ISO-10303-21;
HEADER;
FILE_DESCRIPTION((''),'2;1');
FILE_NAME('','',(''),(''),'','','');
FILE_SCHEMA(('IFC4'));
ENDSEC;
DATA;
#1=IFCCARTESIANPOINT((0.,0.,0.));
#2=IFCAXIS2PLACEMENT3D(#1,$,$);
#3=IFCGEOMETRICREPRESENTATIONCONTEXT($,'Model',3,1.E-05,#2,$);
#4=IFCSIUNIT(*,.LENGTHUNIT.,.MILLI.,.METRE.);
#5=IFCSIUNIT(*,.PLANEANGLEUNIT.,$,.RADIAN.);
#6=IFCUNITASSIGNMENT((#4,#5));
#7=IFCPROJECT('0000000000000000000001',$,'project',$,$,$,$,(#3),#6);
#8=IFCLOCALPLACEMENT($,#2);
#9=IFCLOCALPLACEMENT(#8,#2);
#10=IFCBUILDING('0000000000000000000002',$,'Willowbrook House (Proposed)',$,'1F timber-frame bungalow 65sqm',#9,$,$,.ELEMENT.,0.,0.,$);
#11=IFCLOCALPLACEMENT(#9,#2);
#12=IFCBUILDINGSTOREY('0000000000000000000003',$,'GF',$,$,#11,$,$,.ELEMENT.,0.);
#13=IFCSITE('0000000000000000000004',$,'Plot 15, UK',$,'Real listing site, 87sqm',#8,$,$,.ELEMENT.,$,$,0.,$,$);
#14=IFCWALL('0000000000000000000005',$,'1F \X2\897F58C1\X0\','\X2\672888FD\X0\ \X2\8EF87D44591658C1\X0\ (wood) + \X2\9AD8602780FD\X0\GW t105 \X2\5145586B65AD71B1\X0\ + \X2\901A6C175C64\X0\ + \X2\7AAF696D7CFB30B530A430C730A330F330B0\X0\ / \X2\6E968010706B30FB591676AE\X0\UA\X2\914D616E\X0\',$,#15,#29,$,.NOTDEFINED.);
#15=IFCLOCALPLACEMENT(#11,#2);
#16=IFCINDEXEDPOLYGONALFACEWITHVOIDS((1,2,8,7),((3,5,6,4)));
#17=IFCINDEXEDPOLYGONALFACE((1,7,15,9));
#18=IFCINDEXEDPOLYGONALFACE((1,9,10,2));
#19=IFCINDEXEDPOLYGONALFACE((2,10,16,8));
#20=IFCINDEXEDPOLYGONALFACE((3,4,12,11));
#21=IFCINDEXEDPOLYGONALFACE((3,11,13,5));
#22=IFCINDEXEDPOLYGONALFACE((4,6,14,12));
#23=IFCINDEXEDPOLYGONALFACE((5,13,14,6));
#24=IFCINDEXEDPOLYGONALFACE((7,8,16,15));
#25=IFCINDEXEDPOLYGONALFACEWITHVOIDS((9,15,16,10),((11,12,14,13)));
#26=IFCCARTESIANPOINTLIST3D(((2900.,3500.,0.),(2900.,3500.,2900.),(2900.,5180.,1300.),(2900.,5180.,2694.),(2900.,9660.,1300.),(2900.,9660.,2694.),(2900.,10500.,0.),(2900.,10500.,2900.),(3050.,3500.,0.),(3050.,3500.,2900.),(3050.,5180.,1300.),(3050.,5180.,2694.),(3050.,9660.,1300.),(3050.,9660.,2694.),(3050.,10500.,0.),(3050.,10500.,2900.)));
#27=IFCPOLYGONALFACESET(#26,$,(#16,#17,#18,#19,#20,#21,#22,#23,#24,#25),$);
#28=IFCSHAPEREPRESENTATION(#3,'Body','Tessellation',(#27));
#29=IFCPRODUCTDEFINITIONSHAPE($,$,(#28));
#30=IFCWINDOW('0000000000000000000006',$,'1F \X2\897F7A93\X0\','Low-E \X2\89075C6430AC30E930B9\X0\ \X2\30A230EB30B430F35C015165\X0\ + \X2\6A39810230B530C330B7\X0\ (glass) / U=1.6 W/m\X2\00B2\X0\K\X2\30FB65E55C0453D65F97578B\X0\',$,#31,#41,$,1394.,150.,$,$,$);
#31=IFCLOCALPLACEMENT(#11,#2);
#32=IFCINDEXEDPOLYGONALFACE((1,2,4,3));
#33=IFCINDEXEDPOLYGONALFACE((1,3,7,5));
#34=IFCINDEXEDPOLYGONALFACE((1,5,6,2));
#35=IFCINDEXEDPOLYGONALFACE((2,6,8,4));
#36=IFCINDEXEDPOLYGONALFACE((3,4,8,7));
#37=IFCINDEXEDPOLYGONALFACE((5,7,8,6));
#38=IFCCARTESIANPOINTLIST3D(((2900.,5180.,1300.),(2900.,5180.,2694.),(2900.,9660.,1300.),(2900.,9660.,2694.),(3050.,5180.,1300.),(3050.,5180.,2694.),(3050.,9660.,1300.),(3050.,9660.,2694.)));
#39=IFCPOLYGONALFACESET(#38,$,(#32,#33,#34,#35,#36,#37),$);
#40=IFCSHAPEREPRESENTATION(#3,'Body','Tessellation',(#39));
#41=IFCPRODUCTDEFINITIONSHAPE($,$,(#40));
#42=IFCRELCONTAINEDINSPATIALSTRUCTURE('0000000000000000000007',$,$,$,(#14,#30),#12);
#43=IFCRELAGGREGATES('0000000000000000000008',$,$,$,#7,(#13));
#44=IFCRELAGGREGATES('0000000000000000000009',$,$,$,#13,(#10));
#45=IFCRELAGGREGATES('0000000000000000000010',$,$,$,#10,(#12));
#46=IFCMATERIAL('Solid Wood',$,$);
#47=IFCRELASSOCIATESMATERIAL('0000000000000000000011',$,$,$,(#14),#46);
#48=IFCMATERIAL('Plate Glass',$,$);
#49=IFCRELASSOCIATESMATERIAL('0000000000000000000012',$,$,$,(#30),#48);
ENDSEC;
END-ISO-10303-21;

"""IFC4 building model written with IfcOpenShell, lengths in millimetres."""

from ifc_helpers import new_model, si_unit, frame, frame_2d, origin, place, context, project, spatial, rectangle, extrude, material, element, fill, save


model = new_model("IFC4")

# Units and contexts
model_context = context("Model", 3, precision=1e-05, world=origin())
ifc_project = project(units=[si_unit("LENGTHUNIT", "METRE", prefix="MILLI"), si_unit("PLANEANGLEUNIT", "RADIAN")], contexts=[model_context])

# Site, building, storey
site_placement = place(None, origin())
site = spatial("IfcSite", under=ifc_project, at=site_placement, Name="Plot 15, UK", ObjectType="Real listing site, 87sqm", CompositionType="ELEMENT", RefElevation=0.0)
building_placement = place(site_placement, origin())
building = spatial("IfcBuilding", under=site, at=building_placement, Name="Willowbrook House (Proposed)", ObjectType="1F timber-frame bungalow 65sqm", CompositionType="ELEMENT", ElevationOfRefHeight=0.0, ElevationOfTerrain=0.0)
storey_placement = place(building_placement, origin())
storey = spatial("IfcBuildingStorey", under=building, at=storey_placement, Name="GF", CompositionType="ELEMENT", Elevation=0.0)

# Shared definitions
ifc_material_1 = material(Name="Solid Wood")

# Shared definitions
ifc_material_2 = material(Name="Plate Glass")

# Wall, opening, window
wall_1_placement = place(storey_placement, frame((1450.0, 1750.0, 0.0)))
wall_1 = element("IfcWall", 1, at=wall_1_placement, inside=storey, material=ifc_material_1, Name="1F 西壁", Description="木製 軸組外壁 (wood) + 高性能GW t105 充填断熱 + 通気層 + 窯業系サイディング / 準耐火・外皮UA配慮", PredefinedType="NOTDEFINED", context=model_context, shape_type="SweptSolid", body=[
    extrude(rectangle(XDim=150.0, YDim=7000.0, at=frame_2d((75.0, 3500.0))), frame((1450.0, 1750.0, 0.0)), (0.0, 0.0, 1.0), 2900.0),
])
opening_1_placement = place(storey_placement, frame((1450.0, 2590.0, 650.0)))
opening_1 = element("IfcOpeningElement", 2, at=opening_1_placement, cuts=wall_1, PredefinedType="NOTDEFINED", context=model_context, shape_type="SweptSolid", body=[
    extrude(rectangle(XDim=150.0, YDim=4480.0, at=frame_2d((75.0, 2240.0))), frame((1450.0, 2590.0, 650.0)), (0.0, 0.0, 1.0), 1394.0),
])
window_1_placement = place(storey_placement, frame((1450.0, 2590.0, 650.0)))
window_1 = element("IfcWindow", 3, at=window_1_placement, inside=storey, material=ifc_material_2, Name="1F 西窓", Description="Low-E 複層ガラス アルゴン封入 + 樹脂サッシ (glass) / U=1.6 W/m²K・日射取得型", OverallHeight=1394.0, OverallWidth=150.0, context=model_context, shape_type="SweptSolid", body=[
    extrude(rectangle(XDim=150.0, YDim=4480.0, at=frame_2d((75.0, 2240.0))), frame((1450.0, 2590.0, 650.0)), (0.0, 0.0, 1.0), 1394.0),
])
fill(opening_1, window_1)

save(model, "model.ifc")
